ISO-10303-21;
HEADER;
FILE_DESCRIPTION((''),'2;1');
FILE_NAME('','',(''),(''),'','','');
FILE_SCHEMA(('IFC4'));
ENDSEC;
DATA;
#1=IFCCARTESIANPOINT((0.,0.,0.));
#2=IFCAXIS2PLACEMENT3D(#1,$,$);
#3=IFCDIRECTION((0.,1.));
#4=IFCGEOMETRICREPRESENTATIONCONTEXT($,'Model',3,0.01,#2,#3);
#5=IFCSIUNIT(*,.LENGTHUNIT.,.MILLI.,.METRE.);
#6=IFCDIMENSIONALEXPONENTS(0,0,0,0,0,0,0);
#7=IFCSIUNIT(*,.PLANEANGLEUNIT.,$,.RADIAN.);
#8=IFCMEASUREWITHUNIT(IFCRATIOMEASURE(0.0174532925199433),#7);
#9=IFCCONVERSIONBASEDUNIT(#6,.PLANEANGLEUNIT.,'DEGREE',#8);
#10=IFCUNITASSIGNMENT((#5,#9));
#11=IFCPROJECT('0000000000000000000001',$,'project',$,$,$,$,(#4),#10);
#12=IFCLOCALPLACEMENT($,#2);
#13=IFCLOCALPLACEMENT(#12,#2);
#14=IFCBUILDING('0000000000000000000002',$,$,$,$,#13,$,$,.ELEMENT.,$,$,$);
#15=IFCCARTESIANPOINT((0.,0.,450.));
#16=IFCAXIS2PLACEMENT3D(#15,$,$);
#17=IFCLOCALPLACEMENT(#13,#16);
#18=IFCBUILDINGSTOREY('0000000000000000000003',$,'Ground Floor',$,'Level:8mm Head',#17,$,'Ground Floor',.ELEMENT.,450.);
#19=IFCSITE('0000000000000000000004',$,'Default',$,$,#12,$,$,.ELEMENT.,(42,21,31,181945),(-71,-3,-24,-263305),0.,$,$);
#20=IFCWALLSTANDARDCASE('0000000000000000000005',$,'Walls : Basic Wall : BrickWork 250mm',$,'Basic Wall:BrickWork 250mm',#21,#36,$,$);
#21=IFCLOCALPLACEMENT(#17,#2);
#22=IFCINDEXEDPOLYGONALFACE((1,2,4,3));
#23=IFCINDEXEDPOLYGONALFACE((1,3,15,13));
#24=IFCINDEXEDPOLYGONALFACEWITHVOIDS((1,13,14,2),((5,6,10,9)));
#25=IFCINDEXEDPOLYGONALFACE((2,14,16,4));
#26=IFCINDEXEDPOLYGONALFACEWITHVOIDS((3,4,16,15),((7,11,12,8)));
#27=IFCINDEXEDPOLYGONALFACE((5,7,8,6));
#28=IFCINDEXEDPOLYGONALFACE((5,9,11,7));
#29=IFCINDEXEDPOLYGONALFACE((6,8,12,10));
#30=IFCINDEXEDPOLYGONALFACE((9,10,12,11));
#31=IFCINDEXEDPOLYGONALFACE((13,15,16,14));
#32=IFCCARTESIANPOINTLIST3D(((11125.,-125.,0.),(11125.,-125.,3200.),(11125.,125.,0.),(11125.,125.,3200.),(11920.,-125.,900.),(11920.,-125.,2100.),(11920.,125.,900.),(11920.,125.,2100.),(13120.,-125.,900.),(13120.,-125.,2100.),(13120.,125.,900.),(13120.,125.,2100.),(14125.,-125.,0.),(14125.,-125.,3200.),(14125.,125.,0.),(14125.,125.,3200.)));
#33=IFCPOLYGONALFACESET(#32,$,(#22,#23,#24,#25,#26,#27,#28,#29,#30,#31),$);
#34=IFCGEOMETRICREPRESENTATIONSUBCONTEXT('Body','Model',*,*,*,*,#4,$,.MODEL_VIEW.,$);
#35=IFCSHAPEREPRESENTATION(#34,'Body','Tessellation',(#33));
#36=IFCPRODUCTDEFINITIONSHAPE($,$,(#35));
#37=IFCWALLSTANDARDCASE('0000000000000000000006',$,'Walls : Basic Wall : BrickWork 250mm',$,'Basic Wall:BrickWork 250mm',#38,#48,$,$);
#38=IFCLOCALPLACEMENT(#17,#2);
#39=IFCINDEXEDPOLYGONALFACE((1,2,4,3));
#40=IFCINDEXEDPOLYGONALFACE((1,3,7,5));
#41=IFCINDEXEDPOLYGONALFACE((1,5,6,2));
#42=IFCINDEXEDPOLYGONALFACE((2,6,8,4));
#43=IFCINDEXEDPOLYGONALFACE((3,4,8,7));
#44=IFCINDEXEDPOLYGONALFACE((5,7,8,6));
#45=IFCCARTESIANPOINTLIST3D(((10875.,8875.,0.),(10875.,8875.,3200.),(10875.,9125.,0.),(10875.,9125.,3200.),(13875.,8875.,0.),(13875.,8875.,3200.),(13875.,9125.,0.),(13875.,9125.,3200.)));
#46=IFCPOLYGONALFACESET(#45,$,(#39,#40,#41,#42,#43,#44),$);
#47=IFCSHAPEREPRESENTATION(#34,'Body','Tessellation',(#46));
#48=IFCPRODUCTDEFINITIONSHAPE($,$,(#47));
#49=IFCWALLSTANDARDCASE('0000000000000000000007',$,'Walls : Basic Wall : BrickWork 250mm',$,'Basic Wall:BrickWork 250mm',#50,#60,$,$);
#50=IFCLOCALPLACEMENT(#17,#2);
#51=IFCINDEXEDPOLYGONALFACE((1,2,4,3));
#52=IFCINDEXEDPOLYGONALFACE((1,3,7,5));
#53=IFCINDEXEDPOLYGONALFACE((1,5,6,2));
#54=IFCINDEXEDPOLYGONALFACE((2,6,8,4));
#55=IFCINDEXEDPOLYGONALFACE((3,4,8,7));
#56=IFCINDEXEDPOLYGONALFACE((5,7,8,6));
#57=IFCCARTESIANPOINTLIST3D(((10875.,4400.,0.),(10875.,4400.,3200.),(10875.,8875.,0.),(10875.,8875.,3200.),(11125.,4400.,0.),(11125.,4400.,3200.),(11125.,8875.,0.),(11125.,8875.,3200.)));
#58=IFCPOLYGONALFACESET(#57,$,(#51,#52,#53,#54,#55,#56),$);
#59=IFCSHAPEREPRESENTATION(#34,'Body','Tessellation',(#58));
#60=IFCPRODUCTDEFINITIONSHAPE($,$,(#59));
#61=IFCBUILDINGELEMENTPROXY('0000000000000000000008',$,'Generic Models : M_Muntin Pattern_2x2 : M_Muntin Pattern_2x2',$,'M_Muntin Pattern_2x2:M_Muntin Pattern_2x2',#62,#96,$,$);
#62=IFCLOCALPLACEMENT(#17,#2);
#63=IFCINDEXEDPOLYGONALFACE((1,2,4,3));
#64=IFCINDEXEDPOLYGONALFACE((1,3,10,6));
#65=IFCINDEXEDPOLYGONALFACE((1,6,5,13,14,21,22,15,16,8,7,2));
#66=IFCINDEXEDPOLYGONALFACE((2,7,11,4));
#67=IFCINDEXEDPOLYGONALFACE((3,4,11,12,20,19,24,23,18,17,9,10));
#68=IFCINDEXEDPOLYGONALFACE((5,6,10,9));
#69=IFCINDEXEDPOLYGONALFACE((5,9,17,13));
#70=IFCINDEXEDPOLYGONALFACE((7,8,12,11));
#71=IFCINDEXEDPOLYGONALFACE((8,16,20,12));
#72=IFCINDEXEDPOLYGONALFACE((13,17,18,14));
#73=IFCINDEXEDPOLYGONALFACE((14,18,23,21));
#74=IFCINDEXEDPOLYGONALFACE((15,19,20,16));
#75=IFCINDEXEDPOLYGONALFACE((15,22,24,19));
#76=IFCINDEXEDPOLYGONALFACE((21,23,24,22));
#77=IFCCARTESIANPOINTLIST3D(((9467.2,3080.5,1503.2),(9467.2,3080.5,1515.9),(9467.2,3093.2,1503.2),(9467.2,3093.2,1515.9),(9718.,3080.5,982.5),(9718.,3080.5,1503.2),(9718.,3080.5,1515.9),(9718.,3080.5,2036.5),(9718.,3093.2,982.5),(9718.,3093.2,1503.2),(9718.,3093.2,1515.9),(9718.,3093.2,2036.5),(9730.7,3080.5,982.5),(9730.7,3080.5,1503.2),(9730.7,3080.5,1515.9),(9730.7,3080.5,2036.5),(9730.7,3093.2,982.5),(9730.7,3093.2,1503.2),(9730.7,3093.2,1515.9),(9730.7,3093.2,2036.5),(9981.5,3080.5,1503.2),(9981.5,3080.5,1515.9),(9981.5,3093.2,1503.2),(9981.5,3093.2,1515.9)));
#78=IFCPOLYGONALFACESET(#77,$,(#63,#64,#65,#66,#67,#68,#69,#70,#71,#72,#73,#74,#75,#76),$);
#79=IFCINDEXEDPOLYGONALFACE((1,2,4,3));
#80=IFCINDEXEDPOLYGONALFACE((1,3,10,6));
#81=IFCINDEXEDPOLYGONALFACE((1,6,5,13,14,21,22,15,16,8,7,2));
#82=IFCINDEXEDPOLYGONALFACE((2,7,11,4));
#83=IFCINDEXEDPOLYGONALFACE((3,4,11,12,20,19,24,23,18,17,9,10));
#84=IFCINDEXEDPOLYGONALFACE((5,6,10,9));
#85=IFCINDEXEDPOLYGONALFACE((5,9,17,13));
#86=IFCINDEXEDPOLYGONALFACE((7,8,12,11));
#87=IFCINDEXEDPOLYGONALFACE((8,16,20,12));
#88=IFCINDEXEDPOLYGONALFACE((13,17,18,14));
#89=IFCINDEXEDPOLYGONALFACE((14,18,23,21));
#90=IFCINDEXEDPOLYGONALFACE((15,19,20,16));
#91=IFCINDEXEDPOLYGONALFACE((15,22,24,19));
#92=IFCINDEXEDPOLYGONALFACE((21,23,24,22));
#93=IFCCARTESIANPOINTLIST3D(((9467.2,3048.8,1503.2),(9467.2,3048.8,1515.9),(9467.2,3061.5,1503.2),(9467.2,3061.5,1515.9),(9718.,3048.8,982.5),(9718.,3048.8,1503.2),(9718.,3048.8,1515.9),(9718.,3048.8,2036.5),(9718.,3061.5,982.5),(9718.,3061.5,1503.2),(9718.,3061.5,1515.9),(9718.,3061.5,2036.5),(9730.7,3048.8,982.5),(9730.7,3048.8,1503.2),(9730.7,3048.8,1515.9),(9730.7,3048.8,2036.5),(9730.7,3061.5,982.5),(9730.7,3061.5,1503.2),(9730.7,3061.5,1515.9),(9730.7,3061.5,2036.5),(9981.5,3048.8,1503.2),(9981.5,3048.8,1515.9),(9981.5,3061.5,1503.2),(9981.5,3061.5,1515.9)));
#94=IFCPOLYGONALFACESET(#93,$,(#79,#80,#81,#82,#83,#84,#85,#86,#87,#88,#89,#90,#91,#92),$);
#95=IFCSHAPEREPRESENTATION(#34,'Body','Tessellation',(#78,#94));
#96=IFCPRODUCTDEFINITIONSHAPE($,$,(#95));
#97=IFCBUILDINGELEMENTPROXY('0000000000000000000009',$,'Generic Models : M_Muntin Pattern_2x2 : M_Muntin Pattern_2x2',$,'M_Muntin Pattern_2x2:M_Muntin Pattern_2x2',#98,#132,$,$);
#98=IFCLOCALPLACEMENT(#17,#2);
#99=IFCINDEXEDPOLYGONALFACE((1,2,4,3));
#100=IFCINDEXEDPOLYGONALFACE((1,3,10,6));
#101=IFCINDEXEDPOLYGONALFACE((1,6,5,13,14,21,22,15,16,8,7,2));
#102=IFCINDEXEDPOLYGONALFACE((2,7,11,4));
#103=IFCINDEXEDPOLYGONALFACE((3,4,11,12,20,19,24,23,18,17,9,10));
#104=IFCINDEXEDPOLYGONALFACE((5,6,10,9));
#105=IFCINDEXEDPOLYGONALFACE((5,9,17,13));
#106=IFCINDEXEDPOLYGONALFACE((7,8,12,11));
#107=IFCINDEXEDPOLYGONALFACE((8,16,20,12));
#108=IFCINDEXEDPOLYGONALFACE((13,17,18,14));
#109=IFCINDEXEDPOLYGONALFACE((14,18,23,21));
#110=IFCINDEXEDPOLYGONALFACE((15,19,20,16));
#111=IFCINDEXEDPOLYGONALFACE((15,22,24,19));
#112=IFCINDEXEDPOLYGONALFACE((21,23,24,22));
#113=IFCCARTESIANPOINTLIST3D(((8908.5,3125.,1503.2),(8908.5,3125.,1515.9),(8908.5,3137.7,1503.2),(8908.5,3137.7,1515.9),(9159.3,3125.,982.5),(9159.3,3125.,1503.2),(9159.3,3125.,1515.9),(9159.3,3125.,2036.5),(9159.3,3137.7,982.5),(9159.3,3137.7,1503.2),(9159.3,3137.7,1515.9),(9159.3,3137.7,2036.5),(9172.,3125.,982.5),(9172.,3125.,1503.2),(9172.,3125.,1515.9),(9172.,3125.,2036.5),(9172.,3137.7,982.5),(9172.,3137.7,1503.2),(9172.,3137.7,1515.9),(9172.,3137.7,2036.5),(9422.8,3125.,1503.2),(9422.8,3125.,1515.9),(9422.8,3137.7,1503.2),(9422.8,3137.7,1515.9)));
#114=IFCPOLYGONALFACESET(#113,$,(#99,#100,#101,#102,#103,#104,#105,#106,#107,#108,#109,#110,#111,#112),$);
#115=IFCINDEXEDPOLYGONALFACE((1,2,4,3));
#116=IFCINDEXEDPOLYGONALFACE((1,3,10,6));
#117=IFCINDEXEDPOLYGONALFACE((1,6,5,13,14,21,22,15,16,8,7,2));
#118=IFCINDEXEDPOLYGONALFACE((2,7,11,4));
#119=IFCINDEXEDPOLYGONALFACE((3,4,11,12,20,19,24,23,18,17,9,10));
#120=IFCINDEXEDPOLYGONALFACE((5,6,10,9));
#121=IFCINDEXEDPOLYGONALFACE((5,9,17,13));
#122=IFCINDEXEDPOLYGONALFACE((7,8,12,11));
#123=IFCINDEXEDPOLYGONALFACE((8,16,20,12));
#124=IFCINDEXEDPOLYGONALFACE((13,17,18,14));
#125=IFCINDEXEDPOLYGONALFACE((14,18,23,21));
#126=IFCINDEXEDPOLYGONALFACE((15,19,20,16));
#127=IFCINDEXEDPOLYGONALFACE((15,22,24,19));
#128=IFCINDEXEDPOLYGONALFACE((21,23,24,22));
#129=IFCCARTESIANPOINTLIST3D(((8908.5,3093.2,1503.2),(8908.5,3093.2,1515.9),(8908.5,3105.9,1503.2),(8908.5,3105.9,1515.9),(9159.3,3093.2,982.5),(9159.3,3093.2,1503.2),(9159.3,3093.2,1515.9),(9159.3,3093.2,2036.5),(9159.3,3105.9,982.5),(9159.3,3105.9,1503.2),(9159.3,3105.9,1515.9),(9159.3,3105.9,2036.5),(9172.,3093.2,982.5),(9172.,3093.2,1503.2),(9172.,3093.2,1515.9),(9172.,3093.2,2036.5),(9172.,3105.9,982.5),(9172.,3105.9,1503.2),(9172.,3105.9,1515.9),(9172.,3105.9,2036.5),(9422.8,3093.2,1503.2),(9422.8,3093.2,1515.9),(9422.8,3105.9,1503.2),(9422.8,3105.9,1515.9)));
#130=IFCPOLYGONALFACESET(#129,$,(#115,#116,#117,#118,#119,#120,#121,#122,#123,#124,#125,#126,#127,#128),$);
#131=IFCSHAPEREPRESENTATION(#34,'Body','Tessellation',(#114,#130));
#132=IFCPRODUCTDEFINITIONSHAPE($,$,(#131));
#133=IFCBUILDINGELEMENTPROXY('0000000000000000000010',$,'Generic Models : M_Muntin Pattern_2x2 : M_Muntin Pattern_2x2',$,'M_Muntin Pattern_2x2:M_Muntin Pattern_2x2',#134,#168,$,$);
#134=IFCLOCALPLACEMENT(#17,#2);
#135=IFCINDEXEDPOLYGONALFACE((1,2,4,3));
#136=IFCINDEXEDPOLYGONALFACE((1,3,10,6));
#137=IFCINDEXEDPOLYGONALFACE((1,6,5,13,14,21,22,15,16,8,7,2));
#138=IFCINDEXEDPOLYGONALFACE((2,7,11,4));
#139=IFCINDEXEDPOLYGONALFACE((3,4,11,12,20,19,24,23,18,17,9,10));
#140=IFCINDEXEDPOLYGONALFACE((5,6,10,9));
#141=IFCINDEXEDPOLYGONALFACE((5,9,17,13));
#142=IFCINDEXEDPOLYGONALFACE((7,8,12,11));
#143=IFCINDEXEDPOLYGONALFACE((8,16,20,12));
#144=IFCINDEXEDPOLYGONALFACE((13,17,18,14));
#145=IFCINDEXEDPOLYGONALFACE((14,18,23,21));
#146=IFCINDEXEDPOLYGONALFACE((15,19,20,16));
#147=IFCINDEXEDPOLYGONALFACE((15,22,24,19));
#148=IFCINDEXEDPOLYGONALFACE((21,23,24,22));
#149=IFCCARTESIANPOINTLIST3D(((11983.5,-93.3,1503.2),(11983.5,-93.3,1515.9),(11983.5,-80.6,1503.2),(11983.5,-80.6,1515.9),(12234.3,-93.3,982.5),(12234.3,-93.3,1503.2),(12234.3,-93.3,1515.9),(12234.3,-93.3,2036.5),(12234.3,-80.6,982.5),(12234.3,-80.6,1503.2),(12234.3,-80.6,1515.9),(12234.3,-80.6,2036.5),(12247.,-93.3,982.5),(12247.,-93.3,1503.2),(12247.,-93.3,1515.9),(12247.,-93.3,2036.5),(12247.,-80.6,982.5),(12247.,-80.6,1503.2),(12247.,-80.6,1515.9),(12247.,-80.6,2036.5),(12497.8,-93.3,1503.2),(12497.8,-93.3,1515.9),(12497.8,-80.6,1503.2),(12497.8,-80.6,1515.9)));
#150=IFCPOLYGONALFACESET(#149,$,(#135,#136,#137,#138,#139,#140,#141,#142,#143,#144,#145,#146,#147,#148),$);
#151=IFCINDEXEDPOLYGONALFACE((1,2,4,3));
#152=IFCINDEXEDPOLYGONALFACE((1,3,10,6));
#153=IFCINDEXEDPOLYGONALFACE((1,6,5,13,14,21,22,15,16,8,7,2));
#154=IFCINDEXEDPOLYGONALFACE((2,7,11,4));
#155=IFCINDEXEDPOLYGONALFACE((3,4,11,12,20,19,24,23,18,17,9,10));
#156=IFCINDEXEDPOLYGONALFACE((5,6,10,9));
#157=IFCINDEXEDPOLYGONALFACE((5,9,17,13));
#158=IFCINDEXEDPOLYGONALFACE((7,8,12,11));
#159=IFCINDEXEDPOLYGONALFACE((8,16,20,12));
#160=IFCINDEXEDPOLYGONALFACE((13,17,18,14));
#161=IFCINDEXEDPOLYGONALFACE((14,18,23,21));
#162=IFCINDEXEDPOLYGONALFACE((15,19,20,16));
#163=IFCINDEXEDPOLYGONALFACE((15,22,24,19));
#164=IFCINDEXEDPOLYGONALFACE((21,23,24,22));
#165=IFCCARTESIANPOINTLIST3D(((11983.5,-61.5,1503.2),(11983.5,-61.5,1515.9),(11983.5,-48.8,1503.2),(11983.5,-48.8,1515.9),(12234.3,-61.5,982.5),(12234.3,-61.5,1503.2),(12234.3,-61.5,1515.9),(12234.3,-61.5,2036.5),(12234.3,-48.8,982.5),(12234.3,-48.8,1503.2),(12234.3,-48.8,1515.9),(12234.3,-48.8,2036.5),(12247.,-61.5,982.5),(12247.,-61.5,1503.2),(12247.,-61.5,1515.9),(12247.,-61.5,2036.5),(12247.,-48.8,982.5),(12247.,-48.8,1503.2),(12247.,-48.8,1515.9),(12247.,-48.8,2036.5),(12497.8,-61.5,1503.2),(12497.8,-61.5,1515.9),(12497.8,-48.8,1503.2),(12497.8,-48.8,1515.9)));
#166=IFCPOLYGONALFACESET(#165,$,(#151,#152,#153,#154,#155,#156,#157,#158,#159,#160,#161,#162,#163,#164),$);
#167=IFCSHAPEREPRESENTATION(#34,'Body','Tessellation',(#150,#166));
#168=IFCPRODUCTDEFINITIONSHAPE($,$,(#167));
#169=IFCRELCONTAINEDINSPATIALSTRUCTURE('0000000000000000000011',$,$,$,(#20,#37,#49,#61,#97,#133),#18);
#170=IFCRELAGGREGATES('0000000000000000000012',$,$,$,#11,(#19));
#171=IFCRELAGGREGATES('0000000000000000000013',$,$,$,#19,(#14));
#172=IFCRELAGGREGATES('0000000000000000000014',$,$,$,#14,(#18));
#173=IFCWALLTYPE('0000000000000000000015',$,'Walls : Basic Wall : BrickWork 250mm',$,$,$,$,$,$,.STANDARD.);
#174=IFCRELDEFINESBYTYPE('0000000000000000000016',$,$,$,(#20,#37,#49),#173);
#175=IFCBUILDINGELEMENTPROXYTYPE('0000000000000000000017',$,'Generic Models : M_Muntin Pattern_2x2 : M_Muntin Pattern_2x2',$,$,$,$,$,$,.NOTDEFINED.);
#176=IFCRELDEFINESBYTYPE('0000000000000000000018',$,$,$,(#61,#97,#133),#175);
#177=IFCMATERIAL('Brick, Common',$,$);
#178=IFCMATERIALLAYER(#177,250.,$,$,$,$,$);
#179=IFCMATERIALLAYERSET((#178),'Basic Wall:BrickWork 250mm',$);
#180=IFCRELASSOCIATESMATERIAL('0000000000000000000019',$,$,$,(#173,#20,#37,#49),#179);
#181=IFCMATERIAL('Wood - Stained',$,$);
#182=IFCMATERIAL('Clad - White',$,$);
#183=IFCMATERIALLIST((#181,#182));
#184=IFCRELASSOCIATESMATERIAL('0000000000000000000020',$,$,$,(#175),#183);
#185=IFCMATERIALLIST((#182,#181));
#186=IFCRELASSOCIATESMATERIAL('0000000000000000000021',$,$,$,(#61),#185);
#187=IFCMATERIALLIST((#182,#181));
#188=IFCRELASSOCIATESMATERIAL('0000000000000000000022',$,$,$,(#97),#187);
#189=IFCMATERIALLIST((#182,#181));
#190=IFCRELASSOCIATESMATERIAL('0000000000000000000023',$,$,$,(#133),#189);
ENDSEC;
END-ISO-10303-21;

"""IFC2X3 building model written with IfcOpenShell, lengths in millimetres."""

from ifc_helpers import new_model, entity, si_unit, converted_unit, direction, frame, frame_2d, origin, place, context, subcontext, project, spatial, polyline, rectangle, outline, extrude, clip, halfspace, source, transform, mapped, material, material_list, layer, layer_set, layer_usage, type_object, type_shapes, element, save


model = new_model("IFC2X3")

# Units and contexts
model_context = context("Model", 3, precision=0.01, world=origin(), true_north=direction((0.0, 1.0)))
body_context = subcontext(model_context, "Body", "Model", "MODEL_VIEW")
ifc_project = project(units=[si_unit("LENGTHUNIT", "METRE", prefix="MILLI"), converted_unit("PLANEANGLEUNIT", "DEGREE", entity("IfcRatioMeasure", 0.0174532925199433), si_unit("PLANEANGLEUNIT", "RADIAN"), dimensions=[0, 0, 0, 0, 0, 0, 0])], contexts=[model_context])

# Site, building, storey
site_placement = place(None, origin())
site = spatial("IfcSite", under=ifc_project, at=site_placement, Name="Default", CompositionType="ELEMENT", RefLatitude=(42, 21, 31, 181945), RefLongitude=(-71, -3, -24, -263305), RefElevation=0.0)
building_placement = place(site_placement, origin())
building = spatial("IfcBuilding", under=site, at=building_placement, CompositionType="ELEMENT")
storey_placement = place(building_placement, frame((0.0, 0.0, 450.0)))
storey = spatial("IfcBuildingStorey", under=building, at=storey_placement, Name="Ground Floor", ObjectType="Level:8mm Head", LongName="Ground Floor", CompositionType="ELEMENT", Elevation=450.0)

# Shared definitions
ifc_material_1 = material(Name="Brick, Common")
ifc_layer = layer(ifc_material_1, 250.0)
ifc_layer_set = layer_set([ifc_layer], Name="Basic Wall:BrickWork 250mm")
wall_type = type_object("IfcWallType", Name="Walls : Basic Wall : BrickWork 250mm", PredefinedType="STANDARD", material=ifc_layer_set)

# Wall, opening
ifc_layer_usage_1 = layer_usage(ifc_layer_set, "AXIS2", "POSITIVE", -125.0)
wall_1_placement = place(storey_placement, frame((11125.0, 0.0, 0.0)))
wall_1 = element("IfcWallStandardCase", 1, at=wall_1_placement, inside=storey, type_object=wall_type, material=ifc_layer_usage_1, Name="Walls : Basic Wall : BrickWork 250mm", ObjectType="Basic Wall:BrickWork 250mm", context=body_context, shape_type="Clipping", body=[
    clip(extrude(rectangle(XDim=3000.0, YDim=250.0, at=frame_2d((1500.0, 0.0), x_axis=(-1.0, 0.0))), origin(), (0.0, 0.0, 1.0), 3200.0), halfspace(origin(), True)),
])
opening_1_placement = place(wall_1_placement, frame((1995.0, 125.0, 900.0)))
element("IfcOpeningElement", 2, at=opening_1_placement, cuts=wall_1, ObjectType="Opening", context=body_context, shape_type="SweptSolid", body=[
    extrude(rectangle(XDim=1200.0, YDim=1200.0, at=frame_2d((600.0, 600.0), x_axis=(-1.0, 0.0))), frame((0.0, 0.0, 0.0), z_axis=(0.0, -1.0, 0.0), x_axis=(0.0, 0.0, 1.0)), (0.0, 0.0, 1.0), 250.0),
])

# Walls
ifc_layer_usage_2 = layer_usage(ifc_layer_set, "AXIS2", "POSITIVE", -125.0)
wall_2_placement = place(storey_placement, frame((13875.0, 9000.0, 0.0), z_axis=(0.0, 0.0, 1.0), x_axis=(-1.0, 0.0, 0.0)))
element("IfcWallStandardCase", 3, at=wall_2_placement, inside=storey, type_object=wall_type, material=ifc_layer_usage_2, Name="Walls : Basic Wall : BrickWork 250mm", ObjectType="Basic Wall:BrickWork 250mm", context=body_context, shape_type="Clipping", body=[
    clip(extrude(rectangle(XDim=3000.0, YDim=250.0, at=frame_2d((1500.0, 0.0), x_axis=(-1.0, 0.0))), origin(), (0.0, 0.0, 1.0), 3200.0), halfspace(origin(), True)),
])
ifc_layer_usage_3 = layer_usage(ifc_layer_set, "AXIS2", "POSITIVE", -125.0)
wall_3_placement = place(storey_placement, frame((11000.0, 8875.0, 0.0), z_axis=(0.0, 0.0, 1.0), x_axis=(0.0, -1.0, 0.0)))
element("IfcWallStandardCase", 4, at=wall_3_placement, inside=storey, type_object=wall_type, material=ifc_layer_usage_3, Name="Walls : Basic Wall : BrickWork 250mm", ObjectType="Basic Wall:BrickWork 250mm", context=body_context, shape_type="SweptSolid", body=[
    extrude(rectangle(XDim=4475.0, YDim=250.0, at=frame_2d((2237.5, 0.0), x_axis=(-1.0, 0.0))), origin(), (0.0, 0.0, 1.0), 3200.0),
])

# Building element proxies
ifc_material_2 = material(Name="Clad - White")
ifc_material_3 = material(Name="Wood - Stained")
ifc_material_list_1 = material_list([ifc_material_2, ifc_material_3])
ifc_material_list_2 = material_list([ifc_material_3, ifc_material_2])
building_element_proxy_type_1 = type_object("IfcBuildingElementProxyType", Name="Generic Models : M_Muntin Pattern_2x2 : M_Muntin Pattern_2x2", PredefinedType="NOTDEFINED", material=ifc_material_list_2)
shared_shape_1 = source(origin(), body_context, "Body", "SweptSolid", [
    extrude(outline(polyline([(6.4, -6.4), (527.0, -6.4), (527.0, 6.3), (6.4, 6.3), (6.4, 257.1), (-6.3, 257.1), (-6.3, 6.3), (-527.0, 6.3), (-527.0, -6.4), (-6.3, -6.4), (-6.3, -257.1), (6.4, -257.1), (6.4, -6.4)])), frame((0.0, 9.5, 527.0), z_axis=(0.0, 1.0, 0.0), x_axis=(0.0, 0.0, 1.0)), (0.0, 0.0, 1.0), 12.7),
    extrude(outline(polyline([(6.4, -6.4), (527.0, -6.4), (527.0, 6.3), (6.4, 6.3), (6.4, 257.1), (-6.3, 257.1), (-6.3, 6.3), (-527.0, 6.3), (-527.0, -6.4), (-6.3, -6.4), (-6.3, -257.1), (6.4, -257.1), (6.4, -6.4)])), frame((0.0, -22.2, 527.0), z_axis=(0.0, 1.0, 0.0), x_axis=(0.0, 0.0, 1.0)), (0.0, 0.0, 1.0), 12.7),
])
type_shapes(building_element_proxy_type_1, [shared_shape_1])
proxy_1_placement = place(storey_placement, frame((9724.4, 3071.0, 982.5)))
element("IfcBuildingElementProxy", 5, at=proxy_1_placement, inside=storey, type_object=building_element_proxy_type_1, material=ifc_material_list_1, Name="Generic Models : M_Muntin Pattern_2x2 : M_Muntin Pattern_2x2", ObjectType="M_Muntin Pattern_2x2:M_Muntin Pattern_2x2", context=body_context, shape_type="MappedRepresentation", body=[
    mapped(shared_shape_1, transform((0.0, 0.0, 0.0), scale=1.0)),
])
ifc_material_list_3 = material_list([ifc_material_2, ifc_material_3])
proxy_2_placement = place(storey_placement, frame((9165.6, 3115.5, 982.5)))
element("IfcBuildingElementProxy", 6, at=proxy_2_placement, inside=storey, type_object=building_element_proxy_type_1, material=ifc_material_list_3, Name="Generic Models : M_Muntin Pattern_2x2 : M_Muntin Pattern_2x2", ObjectType="M_Muntin Pattern_2x2:M_Muntin Pattern_2x2", context=body_context, shape_type="MappedRepresentation", body=[
    mapped(shared_shape_1, transform((0.0, 0.0, 0.0), scale=1.0)),
])
ifc_material_list_4 = material_list([ifc_material_2, ifc_material_3])
proxy_3_placement = place(storey_placement, frame((12240.6, -71.0, 982.5), z_axis=(0.0, 0.0, 1.0), x_axis=(-1.0, 0.0, 0.0)))
element("IfcBuildingElementProxy", 7, at=proxy_3_placement, inside=storey, type_object=building_element_proxy_type_1, material=ifc_material_list_4, Name="Generic Models : M_Muntin Pattern_2x2 : M_Muntin Pattern_2x2", ObjectType="M_Muntin Pattern_2x2:M_Muntin Pattern_2x2", context=body_context, shape_type="MappedRepresentation", body=[
    mapped(shared_shape_1, transform((0.0, 0.0, 0.0), scale=1.0)),
])

save(model, "model.ifc")
